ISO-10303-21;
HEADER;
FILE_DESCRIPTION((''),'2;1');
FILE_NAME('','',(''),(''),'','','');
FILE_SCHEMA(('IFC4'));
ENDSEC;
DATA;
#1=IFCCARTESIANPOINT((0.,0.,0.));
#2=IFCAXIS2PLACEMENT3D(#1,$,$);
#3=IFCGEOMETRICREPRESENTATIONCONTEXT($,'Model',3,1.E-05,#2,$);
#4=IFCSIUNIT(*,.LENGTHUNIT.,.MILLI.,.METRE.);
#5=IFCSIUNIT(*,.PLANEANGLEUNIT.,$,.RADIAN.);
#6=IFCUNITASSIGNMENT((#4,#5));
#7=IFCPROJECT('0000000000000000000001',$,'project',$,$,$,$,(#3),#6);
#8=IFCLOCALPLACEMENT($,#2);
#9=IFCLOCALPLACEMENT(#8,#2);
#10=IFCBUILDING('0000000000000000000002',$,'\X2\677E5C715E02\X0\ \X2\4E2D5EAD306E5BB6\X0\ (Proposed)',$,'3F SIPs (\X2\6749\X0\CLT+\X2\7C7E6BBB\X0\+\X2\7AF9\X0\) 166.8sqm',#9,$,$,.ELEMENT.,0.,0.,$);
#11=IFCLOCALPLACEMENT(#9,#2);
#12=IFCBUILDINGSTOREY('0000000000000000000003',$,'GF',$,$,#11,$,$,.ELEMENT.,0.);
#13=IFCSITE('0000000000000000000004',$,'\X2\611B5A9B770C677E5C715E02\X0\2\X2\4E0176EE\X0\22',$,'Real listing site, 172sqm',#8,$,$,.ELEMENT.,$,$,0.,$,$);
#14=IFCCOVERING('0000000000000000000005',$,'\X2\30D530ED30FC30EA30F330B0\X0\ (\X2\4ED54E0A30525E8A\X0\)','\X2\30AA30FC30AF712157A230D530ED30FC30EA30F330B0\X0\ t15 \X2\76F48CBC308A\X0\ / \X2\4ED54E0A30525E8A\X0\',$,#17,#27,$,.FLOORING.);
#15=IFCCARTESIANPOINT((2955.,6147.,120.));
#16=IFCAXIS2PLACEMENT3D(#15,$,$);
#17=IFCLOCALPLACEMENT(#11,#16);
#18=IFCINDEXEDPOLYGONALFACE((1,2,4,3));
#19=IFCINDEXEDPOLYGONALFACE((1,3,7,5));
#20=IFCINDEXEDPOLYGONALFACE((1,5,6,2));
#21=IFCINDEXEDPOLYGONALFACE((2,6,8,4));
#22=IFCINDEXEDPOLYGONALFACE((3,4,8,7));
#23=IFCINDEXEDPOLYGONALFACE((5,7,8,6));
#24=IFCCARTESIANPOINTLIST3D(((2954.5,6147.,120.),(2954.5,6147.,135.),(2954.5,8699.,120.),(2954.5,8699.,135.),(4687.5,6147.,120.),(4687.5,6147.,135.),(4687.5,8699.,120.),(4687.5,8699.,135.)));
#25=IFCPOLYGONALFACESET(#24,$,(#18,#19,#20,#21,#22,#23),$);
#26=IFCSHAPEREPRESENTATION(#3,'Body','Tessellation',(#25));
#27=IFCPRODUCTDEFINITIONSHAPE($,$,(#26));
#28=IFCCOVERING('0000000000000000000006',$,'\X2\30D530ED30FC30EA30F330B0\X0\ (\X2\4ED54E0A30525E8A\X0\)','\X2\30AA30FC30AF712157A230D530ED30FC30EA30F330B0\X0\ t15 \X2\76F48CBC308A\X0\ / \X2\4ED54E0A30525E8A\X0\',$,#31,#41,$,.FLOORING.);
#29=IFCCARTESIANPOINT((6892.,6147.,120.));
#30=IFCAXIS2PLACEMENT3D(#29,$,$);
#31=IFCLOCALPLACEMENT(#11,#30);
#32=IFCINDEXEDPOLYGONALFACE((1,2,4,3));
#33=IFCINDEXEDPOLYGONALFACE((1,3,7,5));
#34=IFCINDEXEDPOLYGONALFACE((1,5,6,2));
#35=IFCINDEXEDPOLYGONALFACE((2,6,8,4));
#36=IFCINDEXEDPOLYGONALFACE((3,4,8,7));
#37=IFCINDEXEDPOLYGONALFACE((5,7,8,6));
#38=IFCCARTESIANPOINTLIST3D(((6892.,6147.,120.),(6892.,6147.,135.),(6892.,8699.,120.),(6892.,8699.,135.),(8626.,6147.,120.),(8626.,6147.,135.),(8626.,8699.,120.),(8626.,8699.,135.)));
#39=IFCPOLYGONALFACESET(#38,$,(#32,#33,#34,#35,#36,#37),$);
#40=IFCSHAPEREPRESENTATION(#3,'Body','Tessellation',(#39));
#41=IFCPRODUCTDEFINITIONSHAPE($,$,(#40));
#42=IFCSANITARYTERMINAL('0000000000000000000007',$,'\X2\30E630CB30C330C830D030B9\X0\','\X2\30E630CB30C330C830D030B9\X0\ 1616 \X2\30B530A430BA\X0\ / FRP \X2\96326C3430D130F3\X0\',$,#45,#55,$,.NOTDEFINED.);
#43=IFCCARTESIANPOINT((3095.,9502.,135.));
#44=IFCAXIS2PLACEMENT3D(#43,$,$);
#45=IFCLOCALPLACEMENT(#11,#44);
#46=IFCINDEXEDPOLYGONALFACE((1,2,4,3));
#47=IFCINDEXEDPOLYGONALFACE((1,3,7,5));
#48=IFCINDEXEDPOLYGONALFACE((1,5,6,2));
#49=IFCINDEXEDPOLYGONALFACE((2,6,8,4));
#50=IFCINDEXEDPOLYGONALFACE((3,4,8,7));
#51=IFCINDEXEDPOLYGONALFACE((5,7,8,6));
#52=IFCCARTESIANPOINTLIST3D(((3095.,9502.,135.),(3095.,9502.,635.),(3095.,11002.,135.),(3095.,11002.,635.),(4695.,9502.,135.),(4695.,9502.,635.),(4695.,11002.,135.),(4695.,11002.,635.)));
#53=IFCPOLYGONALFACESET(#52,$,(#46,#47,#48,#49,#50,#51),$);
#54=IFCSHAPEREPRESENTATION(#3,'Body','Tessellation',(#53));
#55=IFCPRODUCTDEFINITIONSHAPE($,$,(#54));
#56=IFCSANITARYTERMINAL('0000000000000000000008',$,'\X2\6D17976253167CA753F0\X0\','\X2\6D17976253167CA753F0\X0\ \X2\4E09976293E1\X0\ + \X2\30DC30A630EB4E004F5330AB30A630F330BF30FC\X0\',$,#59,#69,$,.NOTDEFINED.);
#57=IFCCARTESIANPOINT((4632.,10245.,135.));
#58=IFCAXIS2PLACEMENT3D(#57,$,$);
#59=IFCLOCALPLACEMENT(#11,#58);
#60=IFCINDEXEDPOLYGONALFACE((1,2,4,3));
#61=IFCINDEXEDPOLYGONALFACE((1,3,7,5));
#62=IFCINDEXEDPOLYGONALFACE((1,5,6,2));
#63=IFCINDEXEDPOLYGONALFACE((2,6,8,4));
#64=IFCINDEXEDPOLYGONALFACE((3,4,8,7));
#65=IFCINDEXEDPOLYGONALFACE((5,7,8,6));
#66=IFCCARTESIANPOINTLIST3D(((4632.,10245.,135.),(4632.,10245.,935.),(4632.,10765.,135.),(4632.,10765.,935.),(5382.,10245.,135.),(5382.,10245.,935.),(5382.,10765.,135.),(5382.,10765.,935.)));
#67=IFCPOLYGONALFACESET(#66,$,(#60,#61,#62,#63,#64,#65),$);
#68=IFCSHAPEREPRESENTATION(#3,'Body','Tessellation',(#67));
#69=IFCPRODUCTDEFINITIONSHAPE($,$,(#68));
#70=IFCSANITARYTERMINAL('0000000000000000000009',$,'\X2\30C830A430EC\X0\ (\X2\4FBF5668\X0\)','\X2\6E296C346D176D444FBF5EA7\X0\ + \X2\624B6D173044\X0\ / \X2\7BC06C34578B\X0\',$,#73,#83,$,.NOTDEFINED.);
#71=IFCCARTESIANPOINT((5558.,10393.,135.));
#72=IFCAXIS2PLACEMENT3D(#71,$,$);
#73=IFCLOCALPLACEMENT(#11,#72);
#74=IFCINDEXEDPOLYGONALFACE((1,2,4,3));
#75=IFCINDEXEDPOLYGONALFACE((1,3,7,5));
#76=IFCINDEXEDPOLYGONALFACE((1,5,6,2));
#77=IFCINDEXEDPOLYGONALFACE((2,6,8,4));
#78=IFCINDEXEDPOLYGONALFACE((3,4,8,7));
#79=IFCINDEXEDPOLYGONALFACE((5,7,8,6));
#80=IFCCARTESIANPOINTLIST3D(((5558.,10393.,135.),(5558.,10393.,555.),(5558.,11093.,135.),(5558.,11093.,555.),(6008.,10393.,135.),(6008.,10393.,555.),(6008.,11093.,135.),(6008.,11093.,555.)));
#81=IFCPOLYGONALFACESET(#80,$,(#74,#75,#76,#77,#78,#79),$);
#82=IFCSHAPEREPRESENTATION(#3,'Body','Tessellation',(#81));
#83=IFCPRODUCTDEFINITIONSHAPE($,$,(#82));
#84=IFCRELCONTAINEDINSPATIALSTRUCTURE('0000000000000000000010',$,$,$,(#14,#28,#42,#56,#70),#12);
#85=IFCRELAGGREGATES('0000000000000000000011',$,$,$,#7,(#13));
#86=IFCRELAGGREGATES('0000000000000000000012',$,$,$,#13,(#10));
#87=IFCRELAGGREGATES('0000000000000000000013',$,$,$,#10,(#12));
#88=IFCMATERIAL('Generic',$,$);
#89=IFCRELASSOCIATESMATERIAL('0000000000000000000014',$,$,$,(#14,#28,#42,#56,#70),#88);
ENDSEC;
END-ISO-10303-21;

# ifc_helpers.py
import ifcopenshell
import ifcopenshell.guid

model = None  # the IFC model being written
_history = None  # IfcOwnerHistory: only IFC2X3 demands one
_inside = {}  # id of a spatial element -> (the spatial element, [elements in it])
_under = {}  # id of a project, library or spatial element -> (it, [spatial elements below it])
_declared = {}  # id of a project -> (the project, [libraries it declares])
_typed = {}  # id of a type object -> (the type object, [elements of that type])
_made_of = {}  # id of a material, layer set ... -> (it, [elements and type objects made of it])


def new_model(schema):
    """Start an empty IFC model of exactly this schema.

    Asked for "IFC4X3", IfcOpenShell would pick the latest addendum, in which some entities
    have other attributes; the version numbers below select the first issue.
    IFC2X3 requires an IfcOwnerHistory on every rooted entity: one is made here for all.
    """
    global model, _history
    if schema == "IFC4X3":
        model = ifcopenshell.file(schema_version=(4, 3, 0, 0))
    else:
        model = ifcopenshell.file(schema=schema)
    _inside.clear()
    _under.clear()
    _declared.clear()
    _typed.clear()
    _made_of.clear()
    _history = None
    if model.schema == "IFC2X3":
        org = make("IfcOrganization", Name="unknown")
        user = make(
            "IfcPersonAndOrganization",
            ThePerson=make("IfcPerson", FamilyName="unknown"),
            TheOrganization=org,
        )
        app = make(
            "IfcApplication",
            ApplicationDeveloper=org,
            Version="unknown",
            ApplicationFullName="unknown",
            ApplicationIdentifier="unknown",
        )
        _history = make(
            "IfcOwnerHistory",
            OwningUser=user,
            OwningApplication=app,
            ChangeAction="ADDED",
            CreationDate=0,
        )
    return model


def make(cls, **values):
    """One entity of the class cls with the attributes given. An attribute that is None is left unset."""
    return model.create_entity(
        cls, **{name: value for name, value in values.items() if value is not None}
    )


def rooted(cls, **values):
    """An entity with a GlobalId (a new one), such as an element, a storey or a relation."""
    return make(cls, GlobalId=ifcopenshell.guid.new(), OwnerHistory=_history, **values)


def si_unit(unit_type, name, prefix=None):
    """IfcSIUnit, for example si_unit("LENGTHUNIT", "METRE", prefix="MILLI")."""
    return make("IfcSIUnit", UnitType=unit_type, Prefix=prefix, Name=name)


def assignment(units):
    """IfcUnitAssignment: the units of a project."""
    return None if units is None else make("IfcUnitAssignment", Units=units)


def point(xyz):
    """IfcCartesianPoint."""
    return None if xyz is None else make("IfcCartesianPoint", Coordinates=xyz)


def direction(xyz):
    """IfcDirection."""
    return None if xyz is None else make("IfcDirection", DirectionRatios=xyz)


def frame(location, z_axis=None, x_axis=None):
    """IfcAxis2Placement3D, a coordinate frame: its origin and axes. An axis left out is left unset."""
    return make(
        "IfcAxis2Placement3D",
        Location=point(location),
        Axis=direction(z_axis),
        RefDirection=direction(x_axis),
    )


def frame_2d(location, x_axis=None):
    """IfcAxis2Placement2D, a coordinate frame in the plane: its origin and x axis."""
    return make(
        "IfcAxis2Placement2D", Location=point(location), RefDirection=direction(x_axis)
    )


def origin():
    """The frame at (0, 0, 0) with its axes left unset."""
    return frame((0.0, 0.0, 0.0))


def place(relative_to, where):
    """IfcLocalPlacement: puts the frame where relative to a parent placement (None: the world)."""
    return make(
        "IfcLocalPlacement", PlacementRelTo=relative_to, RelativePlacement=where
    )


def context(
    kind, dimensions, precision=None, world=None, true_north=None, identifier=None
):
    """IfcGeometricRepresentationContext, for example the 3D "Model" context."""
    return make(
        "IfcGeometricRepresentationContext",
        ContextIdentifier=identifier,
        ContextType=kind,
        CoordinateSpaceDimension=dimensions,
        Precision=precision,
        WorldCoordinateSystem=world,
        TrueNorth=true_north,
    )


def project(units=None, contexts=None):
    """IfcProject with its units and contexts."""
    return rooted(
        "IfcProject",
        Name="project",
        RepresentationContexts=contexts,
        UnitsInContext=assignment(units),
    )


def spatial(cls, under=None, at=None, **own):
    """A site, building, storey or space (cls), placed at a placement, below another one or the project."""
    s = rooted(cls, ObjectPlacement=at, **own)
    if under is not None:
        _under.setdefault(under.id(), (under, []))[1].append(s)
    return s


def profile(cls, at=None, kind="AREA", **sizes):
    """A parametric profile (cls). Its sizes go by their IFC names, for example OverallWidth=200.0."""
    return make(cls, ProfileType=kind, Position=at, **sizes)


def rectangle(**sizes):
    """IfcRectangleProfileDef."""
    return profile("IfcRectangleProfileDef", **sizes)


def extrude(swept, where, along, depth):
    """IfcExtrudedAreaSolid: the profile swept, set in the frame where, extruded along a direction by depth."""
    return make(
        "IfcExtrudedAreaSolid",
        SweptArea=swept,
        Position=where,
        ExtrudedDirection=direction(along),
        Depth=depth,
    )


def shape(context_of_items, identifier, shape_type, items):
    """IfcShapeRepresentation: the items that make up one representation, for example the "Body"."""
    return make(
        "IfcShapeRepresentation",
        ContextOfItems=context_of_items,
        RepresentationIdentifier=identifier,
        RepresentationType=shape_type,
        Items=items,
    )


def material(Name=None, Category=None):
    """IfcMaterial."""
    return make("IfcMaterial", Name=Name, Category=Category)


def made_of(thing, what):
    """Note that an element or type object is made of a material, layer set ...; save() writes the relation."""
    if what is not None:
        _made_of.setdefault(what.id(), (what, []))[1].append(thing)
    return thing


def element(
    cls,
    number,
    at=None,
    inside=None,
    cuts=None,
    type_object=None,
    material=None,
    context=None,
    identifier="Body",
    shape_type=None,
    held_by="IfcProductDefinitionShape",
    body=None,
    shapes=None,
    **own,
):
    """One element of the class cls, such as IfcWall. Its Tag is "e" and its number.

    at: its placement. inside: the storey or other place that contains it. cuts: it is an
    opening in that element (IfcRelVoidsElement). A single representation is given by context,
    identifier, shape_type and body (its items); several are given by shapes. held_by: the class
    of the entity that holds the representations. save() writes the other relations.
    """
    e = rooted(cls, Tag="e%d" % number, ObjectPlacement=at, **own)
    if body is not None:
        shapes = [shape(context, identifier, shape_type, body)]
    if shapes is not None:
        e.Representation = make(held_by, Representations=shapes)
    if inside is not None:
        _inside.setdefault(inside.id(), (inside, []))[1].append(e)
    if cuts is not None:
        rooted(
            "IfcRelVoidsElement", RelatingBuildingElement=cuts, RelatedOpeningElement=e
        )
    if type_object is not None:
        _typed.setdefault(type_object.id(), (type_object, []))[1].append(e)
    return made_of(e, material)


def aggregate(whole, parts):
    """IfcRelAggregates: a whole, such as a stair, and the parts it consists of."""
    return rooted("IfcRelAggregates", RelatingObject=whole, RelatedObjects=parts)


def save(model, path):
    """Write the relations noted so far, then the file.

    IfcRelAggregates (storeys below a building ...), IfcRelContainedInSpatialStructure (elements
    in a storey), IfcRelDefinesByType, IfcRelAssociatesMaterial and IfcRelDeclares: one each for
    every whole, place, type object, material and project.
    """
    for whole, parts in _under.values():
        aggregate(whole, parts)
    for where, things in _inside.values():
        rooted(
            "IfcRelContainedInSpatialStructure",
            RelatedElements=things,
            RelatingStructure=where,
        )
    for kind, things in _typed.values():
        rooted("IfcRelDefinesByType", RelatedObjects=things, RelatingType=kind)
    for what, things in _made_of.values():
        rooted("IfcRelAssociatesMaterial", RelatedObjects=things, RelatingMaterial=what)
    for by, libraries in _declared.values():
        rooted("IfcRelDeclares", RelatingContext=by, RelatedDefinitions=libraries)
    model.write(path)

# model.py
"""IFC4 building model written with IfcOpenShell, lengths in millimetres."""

from ifc_helpers import new_model, si_unit, frame, frame_2d, origin, place, context, project, spatial, rectangle, extrude, material, element, save


model = new_model("IFC4")

# Units and contexts
model_context = context("Model", 3, precision=1e-05, world=origin())
ifc_project = project(units=[si_unit("LENGTHUNIT", "METRE", prefix="MILLI"), si_unit("PLANEANGLEUNIT", "RADIAN")], contexts=[model_context])

# Site, building, storey
site_placement = place(None, origin())
site = spatial("IfcSite", under=ifc_project, at=site_placement, Name="愛媛県松山市2丁目22", ObjectType="Real listing site, 172sqm", CompositionType="ELEMENT", RefElevation=0.0)
building_placement = place(site_placement, origin())
building = spatial("IfcBuilding", under=site, at=building_placement, Name="松山市 中庭の家 (Proposed)", ObjectType="3F SIPs (杉CLT+籾殻+竹) 166.8sqm", CompositionType="ELEMENT", ElevationOfRefHeight=0.0, ElevationOfTerrain=0.0)
storey_placement = place(building_placement, origin())
storey = spatial("IfcBuildingStorey", under=building, at=storey_placement, Name="GF", CompositionType="ELEMENT", Elevation=0.0)

# Coverings
ifc_material_1 = material(Name="Generic")
covering_1_placement = place(storey_placement, frame((2955.0, 6147.0, 120.0)))
element("IfcCovering", 1, at=covering_1_placement, inside=storey, material=ifc_material_1, Name="フローリング (仕上げ床)", Description="オーク無垢フローリング t15 直貼り / 仕上げ床", PredefinedType="FLOORING", context=model_context, shape_type="SweptSolid", body=[
    extrude(rectangle(XDim=1733.0, YDim=2552.0, at=frame_2d((866.0, 1276.0))), frame((2955.0, 6147.0, 120.0)), (0.0, 0.0, 1.0), 15.0),
])
covering_2_placement = place(storey_placement, frame((6892.0, 6147.0, 120.0)))
element("IfcCovering", 2, at=covering_2_placement, inside=storey, material=ifc_material_1, Name="フローリング (仕上げ床)", Description="オーク無垢フローリング t15 直貼り / 仕上げ床", PredefinedType="FLOORING", context=model_context, shape_type="SweptSolid", body=[
    extrude(rectangle(XDim=1734.0, YDim=2552.0, at=frame_2d((867.0, 1276.0))), frame((6892.0, 6147.0, 120.0)), (0.0, 0.0, 1.0), 15.0),
])

# Sanitary terminals
sanitary_terminal_1_placement = place(storey_placement, frame((3095.0, 9502.0, 135.0)))
element("IfcSanitaryTerminal", 3, at=sanitary_terminal_1_placement, inside=storey, material=ifc_material_1, Name="ユニットバス", Description="ユニットバス 1616 サイズ / FRP 防水パン", PredefinedType="NOTDEFINED", context=model_context, shape_type="SweptSolid", body=[
    extrude(rectangle(XDim=1600.0, YDim=1500.0, at=frame_2d((800.0, 750.0))), frame((3095.0, 9502.0, 135.0)), (0.0, 0.0, 1.0), 500.0),
])
sanitary_terminal_2_placement = place(storey_placement, frame((4632.0, 10245.0, 135.0)))
element("IfcSanitaryTerminal", 4, at=sanitary_terminal_2_placement, inside=storey, material=ifc_material_1, Name="洗面化粧台", Description="洗面化粧台 三面鏡 + ボウル一体カウンター", PredefinedType="NOTDEFINED", context=model_context, shape_type="SweptSolid", body=[
    extrude(rectangle(XDim=750.0, YDim=520.0, at=frame_2d((375.0, 260.0))), frame((4632.0, 10245.0, 135.0)), (0.0, 0.0, 1.0), 800.0),
])
sanitary_terminal_3_placement = place(storey_placement, frame((5558.0, 10393.0, 135.0)))
element("IfcSanitaryTerminal", 5, at=sanitary_terminal_3_placement, inside=storey, material=ifc_material_1, Name="トイレ (便器)", Description="温水洗浄便座 + 手洗い / 節水型", PredefinedType="NOTDEFINED", context=model_context, shape_type="SweptSolid", body=[
    extrude(rectangle(XDim=450.0, YDim=700.0, at=frame_2d((225.0, 350.0))), frame((5558.0, 10393.0, 135.0)), (0.0, 0.0, 1.0), 420.0),
])

save(model, "model.ifc")
